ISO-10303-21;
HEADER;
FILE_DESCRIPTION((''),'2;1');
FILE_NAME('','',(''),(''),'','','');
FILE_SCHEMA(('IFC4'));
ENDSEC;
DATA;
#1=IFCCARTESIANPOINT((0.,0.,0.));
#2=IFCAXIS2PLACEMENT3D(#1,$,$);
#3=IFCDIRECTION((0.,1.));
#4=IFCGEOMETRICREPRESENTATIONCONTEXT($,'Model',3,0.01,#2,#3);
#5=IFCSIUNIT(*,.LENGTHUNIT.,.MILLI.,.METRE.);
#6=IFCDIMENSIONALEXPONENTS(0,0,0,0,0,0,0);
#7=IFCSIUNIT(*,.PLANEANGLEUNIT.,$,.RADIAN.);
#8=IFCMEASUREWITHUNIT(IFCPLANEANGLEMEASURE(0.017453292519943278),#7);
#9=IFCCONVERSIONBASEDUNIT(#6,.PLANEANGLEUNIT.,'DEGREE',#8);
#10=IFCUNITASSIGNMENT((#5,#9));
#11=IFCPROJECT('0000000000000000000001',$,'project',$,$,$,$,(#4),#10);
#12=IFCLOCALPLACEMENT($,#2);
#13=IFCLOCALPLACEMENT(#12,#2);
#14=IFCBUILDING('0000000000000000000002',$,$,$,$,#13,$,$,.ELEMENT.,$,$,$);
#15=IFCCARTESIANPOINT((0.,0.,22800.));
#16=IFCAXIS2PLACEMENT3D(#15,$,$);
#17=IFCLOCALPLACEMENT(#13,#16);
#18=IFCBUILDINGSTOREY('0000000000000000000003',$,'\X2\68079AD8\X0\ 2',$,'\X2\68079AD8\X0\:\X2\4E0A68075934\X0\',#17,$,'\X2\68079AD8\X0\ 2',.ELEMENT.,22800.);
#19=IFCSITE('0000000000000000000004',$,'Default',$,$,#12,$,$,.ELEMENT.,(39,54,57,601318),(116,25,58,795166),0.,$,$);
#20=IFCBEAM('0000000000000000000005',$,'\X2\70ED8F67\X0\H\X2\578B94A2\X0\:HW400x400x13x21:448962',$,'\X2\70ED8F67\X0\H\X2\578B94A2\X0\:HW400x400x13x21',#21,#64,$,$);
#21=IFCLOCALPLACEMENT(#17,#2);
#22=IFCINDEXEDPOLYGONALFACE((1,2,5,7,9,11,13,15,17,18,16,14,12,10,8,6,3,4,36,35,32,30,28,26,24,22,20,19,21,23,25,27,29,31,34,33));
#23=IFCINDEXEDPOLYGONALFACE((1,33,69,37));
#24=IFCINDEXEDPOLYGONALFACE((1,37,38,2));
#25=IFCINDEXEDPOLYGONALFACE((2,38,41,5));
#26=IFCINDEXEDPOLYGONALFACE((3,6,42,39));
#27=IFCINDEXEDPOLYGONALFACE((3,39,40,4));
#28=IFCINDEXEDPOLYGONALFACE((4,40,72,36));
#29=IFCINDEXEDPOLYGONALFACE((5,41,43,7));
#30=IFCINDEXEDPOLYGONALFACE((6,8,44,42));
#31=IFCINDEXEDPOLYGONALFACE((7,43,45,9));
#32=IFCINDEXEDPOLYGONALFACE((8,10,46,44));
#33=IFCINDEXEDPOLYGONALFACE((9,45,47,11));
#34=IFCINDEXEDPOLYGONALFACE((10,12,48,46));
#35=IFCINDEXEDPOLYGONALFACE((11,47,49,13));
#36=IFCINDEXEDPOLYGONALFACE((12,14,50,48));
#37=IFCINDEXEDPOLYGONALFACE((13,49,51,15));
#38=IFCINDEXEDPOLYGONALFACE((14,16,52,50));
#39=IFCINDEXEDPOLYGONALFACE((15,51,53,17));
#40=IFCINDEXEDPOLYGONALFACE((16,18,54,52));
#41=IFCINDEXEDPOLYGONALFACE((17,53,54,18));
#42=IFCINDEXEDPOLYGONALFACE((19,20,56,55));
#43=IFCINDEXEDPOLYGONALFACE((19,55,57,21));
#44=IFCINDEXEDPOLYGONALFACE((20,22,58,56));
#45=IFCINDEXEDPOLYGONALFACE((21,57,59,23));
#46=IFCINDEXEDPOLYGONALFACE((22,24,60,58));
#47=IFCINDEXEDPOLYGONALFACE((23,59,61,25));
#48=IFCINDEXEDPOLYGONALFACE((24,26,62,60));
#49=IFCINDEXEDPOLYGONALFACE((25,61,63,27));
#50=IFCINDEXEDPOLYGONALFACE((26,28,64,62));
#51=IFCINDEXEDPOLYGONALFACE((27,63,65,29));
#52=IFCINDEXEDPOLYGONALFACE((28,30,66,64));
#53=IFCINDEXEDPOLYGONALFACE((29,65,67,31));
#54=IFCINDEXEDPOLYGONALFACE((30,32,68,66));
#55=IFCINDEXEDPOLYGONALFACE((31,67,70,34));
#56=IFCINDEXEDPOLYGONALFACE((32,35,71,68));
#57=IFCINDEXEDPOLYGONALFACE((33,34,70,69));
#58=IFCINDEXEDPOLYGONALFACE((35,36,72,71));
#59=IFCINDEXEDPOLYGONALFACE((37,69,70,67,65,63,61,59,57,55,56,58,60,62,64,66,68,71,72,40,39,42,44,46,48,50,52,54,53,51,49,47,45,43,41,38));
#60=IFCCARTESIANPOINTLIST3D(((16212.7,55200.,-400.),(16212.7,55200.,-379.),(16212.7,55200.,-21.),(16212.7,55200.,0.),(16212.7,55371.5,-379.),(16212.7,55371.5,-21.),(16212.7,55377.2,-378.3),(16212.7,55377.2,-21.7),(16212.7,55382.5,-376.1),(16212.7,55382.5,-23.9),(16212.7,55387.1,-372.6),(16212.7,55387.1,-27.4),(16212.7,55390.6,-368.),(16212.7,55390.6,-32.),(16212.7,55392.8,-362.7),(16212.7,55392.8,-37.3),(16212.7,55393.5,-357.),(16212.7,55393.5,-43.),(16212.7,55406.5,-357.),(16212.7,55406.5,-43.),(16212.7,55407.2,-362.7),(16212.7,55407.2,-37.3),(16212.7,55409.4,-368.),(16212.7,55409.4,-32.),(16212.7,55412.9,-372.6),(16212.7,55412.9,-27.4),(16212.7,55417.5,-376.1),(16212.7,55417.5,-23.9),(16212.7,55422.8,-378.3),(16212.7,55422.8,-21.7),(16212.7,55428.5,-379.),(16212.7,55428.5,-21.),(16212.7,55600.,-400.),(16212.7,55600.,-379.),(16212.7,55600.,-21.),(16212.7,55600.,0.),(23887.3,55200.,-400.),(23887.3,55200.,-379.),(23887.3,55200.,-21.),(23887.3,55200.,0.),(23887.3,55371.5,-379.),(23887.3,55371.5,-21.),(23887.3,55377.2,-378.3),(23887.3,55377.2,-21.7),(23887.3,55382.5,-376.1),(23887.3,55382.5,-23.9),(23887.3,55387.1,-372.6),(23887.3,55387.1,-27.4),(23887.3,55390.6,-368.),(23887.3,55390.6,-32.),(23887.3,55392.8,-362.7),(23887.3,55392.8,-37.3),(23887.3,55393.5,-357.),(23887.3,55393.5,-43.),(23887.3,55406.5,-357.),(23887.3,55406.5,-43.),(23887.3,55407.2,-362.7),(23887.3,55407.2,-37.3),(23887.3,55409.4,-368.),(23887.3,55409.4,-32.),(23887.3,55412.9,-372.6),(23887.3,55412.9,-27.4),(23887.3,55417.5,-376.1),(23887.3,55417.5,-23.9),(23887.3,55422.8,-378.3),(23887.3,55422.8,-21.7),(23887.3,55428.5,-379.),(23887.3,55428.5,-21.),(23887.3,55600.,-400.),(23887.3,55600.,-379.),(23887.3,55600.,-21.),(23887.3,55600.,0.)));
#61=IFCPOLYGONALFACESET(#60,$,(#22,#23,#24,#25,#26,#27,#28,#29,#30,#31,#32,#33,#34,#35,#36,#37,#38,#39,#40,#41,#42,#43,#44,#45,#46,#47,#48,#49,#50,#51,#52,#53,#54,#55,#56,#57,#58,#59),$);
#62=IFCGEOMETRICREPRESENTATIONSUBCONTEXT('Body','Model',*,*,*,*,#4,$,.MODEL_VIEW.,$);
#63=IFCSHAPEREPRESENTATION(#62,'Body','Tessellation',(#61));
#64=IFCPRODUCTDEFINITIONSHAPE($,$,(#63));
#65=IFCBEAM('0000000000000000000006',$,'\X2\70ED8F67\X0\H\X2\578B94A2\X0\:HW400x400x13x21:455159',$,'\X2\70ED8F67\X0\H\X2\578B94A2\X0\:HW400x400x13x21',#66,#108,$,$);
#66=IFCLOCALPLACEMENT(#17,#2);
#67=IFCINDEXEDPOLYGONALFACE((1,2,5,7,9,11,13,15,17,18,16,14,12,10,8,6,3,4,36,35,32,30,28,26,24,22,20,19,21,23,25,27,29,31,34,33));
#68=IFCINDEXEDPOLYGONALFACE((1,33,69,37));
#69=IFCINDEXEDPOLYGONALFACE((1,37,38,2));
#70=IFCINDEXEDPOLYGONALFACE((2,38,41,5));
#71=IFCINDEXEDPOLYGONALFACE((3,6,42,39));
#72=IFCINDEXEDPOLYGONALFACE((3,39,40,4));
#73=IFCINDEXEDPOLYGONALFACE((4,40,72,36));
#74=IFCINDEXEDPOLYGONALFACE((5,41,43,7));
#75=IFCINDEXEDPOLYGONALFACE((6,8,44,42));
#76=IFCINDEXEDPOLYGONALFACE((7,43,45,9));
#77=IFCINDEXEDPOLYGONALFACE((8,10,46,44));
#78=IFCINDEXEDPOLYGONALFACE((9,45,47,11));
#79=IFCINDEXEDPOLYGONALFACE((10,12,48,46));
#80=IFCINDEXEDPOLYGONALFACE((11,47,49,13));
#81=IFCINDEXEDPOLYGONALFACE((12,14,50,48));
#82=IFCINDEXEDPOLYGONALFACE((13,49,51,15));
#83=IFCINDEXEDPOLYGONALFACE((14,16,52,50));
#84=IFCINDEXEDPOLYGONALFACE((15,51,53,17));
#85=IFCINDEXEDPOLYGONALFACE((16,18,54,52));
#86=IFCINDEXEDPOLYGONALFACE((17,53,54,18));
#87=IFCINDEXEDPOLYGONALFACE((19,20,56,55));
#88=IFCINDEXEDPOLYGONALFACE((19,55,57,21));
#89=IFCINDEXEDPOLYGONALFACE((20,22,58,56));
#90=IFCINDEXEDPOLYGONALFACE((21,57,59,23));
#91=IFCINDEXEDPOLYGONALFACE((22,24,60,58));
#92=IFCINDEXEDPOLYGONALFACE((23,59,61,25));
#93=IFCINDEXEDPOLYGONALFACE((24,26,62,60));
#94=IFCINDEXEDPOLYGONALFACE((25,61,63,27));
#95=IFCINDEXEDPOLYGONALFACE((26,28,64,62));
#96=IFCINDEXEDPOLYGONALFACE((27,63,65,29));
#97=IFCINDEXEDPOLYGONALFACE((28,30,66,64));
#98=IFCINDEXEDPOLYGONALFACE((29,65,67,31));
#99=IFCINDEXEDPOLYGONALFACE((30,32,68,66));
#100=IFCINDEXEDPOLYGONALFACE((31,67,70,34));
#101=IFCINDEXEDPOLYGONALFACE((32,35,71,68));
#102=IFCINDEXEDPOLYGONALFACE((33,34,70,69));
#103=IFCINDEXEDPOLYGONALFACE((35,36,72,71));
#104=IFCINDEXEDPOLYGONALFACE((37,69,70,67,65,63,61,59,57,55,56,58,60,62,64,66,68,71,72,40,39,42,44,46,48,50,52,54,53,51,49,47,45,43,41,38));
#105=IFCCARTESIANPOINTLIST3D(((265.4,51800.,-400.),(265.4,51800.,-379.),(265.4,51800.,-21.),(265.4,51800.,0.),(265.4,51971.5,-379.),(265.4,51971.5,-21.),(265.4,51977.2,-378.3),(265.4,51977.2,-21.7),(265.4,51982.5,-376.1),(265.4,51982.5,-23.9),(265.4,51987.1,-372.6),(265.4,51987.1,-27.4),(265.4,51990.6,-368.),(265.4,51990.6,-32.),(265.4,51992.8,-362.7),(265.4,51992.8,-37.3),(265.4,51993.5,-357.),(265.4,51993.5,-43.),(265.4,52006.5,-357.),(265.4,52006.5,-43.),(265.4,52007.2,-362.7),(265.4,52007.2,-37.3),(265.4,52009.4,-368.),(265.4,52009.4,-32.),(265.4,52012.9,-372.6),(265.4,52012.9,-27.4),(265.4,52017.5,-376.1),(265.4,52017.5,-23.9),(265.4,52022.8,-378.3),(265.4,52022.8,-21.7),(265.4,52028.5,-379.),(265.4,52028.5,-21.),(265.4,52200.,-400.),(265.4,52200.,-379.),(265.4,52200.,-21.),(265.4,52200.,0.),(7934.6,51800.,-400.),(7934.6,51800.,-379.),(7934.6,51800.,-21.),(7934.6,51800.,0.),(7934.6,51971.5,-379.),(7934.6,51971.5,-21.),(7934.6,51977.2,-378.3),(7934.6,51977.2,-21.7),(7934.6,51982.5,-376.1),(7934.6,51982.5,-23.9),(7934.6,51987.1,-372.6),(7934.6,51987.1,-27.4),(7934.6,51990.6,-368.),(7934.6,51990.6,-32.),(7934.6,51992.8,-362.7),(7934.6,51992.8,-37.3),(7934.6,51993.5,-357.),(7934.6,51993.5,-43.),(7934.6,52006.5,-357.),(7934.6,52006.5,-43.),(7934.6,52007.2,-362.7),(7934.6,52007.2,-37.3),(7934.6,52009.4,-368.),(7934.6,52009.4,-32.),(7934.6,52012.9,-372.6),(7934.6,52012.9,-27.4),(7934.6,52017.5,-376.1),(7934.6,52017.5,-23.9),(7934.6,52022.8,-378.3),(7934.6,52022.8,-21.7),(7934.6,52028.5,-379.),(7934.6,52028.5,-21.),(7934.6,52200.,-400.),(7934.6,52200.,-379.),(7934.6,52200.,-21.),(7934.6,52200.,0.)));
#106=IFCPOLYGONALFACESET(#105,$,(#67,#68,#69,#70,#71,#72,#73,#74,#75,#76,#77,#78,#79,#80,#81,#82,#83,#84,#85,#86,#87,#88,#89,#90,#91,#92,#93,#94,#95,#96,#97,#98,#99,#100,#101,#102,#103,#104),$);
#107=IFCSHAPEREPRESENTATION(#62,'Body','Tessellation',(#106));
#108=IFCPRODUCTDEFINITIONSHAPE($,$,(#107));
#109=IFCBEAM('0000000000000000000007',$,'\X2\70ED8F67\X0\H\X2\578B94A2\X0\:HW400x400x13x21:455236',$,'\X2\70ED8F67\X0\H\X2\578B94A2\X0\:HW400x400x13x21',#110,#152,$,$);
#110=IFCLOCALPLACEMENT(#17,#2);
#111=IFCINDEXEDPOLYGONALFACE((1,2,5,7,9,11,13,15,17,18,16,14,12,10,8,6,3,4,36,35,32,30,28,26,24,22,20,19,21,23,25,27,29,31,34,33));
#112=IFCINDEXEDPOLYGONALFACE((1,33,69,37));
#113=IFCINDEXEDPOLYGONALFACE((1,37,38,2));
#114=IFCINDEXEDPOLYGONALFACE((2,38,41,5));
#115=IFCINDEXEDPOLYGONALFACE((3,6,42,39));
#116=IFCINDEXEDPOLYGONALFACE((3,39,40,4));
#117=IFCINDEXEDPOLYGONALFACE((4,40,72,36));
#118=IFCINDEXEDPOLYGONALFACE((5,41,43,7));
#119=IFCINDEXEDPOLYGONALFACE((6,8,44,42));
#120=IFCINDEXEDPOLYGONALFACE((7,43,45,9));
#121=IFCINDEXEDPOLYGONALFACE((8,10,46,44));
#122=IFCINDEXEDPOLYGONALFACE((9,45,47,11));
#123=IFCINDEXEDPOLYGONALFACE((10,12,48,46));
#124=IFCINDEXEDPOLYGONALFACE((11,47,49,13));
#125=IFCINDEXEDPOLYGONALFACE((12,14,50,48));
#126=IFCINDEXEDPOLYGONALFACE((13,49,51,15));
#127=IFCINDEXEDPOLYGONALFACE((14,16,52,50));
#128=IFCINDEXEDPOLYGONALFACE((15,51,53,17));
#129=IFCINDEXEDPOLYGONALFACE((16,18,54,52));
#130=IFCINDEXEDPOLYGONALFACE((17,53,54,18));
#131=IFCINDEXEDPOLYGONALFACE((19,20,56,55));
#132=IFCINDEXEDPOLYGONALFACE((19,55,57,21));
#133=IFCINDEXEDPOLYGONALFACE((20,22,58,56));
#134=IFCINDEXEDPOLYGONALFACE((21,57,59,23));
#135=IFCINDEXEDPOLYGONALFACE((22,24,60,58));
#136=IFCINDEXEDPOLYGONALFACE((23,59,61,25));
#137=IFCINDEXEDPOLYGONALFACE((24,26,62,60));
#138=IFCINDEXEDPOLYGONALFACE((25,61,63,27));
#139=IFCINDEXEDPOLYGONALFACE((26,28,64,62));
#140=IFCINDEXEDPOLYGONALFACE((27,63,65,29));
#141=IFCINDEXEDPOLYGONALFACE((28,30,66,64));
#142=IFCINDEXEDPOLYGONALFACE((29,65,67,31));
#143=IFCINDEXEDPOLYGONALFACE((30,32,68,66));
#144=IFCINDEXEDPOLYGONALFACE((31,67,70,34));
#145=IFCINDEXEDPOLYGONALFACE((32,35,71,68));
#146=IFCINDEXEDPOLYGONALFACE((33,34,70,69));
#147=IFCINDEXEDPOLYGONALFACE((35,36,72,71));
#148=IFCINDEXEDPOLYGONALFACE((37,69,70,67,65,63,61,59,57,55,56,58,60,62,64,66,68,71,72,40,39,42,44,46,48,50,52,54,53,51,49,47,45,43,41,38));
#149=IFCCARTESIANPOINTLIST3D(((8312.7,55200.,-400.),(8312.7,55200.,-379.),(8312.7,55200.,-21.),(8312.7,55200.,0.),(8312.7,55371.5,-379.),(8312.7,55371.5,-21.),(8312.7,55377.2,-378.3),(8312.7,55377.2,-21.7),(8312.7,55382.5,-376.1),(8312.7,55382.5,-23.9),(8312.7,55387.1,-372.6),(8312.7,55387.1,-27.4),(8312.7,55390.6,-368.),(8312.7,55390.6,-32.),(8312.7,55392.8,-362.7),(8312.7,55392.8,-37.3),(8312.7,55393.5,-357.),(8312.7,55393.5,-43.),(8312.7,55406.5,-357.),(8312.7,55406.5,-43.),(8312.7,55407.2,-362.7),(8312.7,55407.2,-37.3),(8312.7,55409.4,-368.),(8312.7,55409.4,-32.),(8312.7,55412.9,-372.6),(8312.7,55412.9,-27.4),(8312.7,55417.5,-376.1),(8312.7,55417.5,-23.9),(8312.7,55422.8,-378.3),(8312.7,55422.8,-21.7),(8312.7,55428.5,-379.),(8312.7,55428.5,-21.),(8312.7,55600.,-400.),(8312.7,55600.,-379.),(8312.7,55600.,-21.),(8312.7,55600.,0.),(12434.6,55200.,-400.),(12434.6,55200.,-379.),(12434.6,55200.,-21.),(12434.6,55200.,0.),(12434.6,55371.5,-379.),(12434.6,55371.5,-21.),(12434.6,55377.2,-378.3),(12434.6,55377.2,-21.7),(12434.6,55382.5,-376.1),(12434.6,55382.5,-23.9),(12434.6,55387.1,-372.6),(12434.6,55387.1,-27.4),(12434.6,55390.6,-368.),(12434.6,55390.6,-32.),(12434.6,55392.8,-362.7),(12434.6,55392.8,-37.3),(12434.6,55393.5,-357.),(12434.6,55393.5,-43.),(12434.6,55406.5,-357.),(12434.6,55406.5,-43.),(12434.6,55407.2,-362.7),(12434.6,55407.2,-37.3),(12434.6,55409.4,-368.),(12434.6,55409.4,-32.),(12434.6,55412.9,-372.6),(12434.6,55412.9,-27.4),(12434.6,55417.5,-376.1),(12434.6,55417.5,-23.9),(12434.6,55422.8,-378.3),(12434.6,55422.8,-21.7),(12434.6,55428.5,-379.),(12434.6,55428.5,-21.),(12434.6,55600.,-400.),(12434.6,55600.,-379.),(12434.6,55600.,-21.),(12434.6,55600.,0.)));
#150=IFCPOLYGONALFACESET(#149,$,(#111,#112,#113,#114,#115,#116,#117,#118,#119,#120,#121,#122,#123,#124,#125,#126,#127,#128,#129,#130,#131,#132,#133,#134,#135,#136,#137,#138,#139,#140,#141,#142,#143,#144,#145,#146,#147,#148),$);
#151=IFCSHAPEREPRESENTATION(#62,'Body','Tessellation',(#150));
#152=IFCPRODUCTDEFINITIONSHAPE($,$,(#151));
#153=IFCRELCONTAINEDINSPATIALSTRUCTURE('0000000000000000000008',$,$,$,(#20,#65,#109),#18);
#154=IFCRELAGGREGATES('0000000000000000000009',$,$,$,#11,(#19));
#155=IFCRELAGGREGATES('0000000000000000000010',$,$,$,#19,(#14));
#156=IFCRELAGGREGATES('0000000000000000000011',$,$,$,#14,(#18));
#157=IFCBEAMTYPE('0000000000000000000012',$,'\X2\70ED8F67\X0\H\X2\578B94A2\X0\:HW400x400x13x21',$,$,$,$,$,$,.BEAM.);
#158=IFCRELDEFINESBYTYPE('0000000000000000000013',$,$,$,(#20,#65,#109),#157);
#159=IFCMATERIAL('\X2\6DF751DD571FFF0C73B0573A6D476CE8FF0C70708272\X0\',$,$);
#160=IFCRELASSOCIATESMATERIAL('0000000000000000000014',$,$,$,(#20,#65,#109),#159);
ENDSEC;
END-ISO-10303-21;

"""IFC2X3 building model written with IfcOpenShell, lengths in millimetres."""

from ifc_helpers import new_model, entity, si_unit, converted_unit, direction, frame, frame_2d, origin, place, context, subcontext, project, spatial, i_section, extrude, material, type_object, element, save


model = new_model("IFC2X3")

# Units and contexts
model_context = context("Model", 3, precision=0.01, world=origin(), true_north=direction((0.0, 1.0)))
body_context = subcontext(model_context, "Body", "Model", "MODEL_VIEW")
ifc_project = project(units=[si_unit("LENGTHUNIT", "METRE", prefix="MILLI"), converted_unit("PLANEANGLEUNIT", "DEGREE", entity("IfcPlaneAngleMeasure", 0.017453292519943278), si_unit("PLANEANGLEUNIT", "RADIAN"), dimensions=[0, 0, 0, 0, 0, 0, 0])], contexts=[model_context])

# Site, building, storey
site_placement = place(None, origin())
site = spatial("IfcSite", under=ifc_project, at=site_placement, Name="Default", CompositionType="ELEMENT", RefLatitude=(39, 54, 57, 601318), RefLongitude=(116, 25, 58, 795166), RefElevation=0.0)
building_placement = place(site_placement, origin())
building = spatial("IfcBuilding", under=site, at=building_placement, CompositionType="ELEMENT")
storey_placement = place(building_placement, frame((0.0, 0.0, 22800.0)))
storey = spatial("IfcBuildingStorey", under=building, at=storey_placement, Name="标高 2", ObjectType="标高:上标头", LongName="标高 2", CompositionType="ELEMENT", Elevation=22800.0)

# Beams
ifc_material = material(Name="混凝土，现场浇注，灰色")
beam_type = type_object("IfcBeamType", Name="热轧H型钢:HW400x400x13x21", PredefinedType="BEAM")
beam_1_placement = place(storey_placement, frame((24100.0, 55400.0, 0.0), z_axis=(0.0, 0.0, 1.0), x_axis=(-1.0, 0.0, 0.0)))
element("IfcBeam", 1, at=beam_1_placement, inside=storey, type_object=beam_type, material=ifc_material, Name="热轧H型钢:HW400x400x13x21:448962", ObjectType="热轧H型钢:HW400x400x13x21", context=body_context, shape_type="SweptSolid", body=[
    extrude(i_section(OverallWidth=400.0, OverallDepth=400.0, WebThickness=13.0, FlangeThickness=21.0, FilletRadius=22.0, at=frame_2d((0.0, 0.0), x_axis=(0.0, 1.0))), frame((212.7, 0.0, -200.0), z_axis=(1.0, 0.0, 0.0), x_axis=(0.0, 0.0, -1.0)), (0.0, 0.0, 1.0), 7674.6),
])
beam_2_placement = place(storey_placement, frame((100.0, 52000.0, 0.0)))
element("IfcBeam", 2, at=beam_2_placement, inside=storey, type_object=beam_type, material=ifc_material, Name="热轧H型钢:HW400x400x13x21:455159", ObjectType="热轧H型钢:HW400x400x13x21", context=body_context, shape_type="SweptSolid", body=[
    extrude(i_section(OverallWidth=400.0, OverallDepth=400.0, WebThickness=13.0, FlangeThickness=21.0, FilletRadius=22.0, at=frame_2d((0.0, 0.0), x_axis=(0.0, 1.0))), frame((165.4, 0.0, -200.0), z_axis=(1.0, 0.0, 0.0), x_axis=(0.0, 0.0, -1.0)), (0.0, 0.0, 1.0), 7669.2),
])
beam_3_placement = place(storey_placement, frame((8100.0, 55400.0, 0.0)))
element("IfcBeam", 3, at=beam_3_placement, inside=storey, type_object=beam_type, material=ifc_material, Name="热轧H型钢:HW400x400x13x21:455236", ObjectType="热轧H型钢:HW400x400x13x21", context=body_context, shape_type="SweptSolid", body=[
    extrude(i_section(OverallWidth=400.0, OverallDepth=400.0, WebThickness=13.0, FlangeThickness=21.0, FilletRadius=22.0, at=frame_2d((0.0, 0.0), x_axis=(0.0, 1.0))), frame((212.7, 0.0, -200.0), z_axis=(1.0, 0.0, 0.0), x_axis=(0.0, 0.0, -1.0)), (0.0, 0.0, 1.0), 4121.9),
])

save(model, "model.ifc")
